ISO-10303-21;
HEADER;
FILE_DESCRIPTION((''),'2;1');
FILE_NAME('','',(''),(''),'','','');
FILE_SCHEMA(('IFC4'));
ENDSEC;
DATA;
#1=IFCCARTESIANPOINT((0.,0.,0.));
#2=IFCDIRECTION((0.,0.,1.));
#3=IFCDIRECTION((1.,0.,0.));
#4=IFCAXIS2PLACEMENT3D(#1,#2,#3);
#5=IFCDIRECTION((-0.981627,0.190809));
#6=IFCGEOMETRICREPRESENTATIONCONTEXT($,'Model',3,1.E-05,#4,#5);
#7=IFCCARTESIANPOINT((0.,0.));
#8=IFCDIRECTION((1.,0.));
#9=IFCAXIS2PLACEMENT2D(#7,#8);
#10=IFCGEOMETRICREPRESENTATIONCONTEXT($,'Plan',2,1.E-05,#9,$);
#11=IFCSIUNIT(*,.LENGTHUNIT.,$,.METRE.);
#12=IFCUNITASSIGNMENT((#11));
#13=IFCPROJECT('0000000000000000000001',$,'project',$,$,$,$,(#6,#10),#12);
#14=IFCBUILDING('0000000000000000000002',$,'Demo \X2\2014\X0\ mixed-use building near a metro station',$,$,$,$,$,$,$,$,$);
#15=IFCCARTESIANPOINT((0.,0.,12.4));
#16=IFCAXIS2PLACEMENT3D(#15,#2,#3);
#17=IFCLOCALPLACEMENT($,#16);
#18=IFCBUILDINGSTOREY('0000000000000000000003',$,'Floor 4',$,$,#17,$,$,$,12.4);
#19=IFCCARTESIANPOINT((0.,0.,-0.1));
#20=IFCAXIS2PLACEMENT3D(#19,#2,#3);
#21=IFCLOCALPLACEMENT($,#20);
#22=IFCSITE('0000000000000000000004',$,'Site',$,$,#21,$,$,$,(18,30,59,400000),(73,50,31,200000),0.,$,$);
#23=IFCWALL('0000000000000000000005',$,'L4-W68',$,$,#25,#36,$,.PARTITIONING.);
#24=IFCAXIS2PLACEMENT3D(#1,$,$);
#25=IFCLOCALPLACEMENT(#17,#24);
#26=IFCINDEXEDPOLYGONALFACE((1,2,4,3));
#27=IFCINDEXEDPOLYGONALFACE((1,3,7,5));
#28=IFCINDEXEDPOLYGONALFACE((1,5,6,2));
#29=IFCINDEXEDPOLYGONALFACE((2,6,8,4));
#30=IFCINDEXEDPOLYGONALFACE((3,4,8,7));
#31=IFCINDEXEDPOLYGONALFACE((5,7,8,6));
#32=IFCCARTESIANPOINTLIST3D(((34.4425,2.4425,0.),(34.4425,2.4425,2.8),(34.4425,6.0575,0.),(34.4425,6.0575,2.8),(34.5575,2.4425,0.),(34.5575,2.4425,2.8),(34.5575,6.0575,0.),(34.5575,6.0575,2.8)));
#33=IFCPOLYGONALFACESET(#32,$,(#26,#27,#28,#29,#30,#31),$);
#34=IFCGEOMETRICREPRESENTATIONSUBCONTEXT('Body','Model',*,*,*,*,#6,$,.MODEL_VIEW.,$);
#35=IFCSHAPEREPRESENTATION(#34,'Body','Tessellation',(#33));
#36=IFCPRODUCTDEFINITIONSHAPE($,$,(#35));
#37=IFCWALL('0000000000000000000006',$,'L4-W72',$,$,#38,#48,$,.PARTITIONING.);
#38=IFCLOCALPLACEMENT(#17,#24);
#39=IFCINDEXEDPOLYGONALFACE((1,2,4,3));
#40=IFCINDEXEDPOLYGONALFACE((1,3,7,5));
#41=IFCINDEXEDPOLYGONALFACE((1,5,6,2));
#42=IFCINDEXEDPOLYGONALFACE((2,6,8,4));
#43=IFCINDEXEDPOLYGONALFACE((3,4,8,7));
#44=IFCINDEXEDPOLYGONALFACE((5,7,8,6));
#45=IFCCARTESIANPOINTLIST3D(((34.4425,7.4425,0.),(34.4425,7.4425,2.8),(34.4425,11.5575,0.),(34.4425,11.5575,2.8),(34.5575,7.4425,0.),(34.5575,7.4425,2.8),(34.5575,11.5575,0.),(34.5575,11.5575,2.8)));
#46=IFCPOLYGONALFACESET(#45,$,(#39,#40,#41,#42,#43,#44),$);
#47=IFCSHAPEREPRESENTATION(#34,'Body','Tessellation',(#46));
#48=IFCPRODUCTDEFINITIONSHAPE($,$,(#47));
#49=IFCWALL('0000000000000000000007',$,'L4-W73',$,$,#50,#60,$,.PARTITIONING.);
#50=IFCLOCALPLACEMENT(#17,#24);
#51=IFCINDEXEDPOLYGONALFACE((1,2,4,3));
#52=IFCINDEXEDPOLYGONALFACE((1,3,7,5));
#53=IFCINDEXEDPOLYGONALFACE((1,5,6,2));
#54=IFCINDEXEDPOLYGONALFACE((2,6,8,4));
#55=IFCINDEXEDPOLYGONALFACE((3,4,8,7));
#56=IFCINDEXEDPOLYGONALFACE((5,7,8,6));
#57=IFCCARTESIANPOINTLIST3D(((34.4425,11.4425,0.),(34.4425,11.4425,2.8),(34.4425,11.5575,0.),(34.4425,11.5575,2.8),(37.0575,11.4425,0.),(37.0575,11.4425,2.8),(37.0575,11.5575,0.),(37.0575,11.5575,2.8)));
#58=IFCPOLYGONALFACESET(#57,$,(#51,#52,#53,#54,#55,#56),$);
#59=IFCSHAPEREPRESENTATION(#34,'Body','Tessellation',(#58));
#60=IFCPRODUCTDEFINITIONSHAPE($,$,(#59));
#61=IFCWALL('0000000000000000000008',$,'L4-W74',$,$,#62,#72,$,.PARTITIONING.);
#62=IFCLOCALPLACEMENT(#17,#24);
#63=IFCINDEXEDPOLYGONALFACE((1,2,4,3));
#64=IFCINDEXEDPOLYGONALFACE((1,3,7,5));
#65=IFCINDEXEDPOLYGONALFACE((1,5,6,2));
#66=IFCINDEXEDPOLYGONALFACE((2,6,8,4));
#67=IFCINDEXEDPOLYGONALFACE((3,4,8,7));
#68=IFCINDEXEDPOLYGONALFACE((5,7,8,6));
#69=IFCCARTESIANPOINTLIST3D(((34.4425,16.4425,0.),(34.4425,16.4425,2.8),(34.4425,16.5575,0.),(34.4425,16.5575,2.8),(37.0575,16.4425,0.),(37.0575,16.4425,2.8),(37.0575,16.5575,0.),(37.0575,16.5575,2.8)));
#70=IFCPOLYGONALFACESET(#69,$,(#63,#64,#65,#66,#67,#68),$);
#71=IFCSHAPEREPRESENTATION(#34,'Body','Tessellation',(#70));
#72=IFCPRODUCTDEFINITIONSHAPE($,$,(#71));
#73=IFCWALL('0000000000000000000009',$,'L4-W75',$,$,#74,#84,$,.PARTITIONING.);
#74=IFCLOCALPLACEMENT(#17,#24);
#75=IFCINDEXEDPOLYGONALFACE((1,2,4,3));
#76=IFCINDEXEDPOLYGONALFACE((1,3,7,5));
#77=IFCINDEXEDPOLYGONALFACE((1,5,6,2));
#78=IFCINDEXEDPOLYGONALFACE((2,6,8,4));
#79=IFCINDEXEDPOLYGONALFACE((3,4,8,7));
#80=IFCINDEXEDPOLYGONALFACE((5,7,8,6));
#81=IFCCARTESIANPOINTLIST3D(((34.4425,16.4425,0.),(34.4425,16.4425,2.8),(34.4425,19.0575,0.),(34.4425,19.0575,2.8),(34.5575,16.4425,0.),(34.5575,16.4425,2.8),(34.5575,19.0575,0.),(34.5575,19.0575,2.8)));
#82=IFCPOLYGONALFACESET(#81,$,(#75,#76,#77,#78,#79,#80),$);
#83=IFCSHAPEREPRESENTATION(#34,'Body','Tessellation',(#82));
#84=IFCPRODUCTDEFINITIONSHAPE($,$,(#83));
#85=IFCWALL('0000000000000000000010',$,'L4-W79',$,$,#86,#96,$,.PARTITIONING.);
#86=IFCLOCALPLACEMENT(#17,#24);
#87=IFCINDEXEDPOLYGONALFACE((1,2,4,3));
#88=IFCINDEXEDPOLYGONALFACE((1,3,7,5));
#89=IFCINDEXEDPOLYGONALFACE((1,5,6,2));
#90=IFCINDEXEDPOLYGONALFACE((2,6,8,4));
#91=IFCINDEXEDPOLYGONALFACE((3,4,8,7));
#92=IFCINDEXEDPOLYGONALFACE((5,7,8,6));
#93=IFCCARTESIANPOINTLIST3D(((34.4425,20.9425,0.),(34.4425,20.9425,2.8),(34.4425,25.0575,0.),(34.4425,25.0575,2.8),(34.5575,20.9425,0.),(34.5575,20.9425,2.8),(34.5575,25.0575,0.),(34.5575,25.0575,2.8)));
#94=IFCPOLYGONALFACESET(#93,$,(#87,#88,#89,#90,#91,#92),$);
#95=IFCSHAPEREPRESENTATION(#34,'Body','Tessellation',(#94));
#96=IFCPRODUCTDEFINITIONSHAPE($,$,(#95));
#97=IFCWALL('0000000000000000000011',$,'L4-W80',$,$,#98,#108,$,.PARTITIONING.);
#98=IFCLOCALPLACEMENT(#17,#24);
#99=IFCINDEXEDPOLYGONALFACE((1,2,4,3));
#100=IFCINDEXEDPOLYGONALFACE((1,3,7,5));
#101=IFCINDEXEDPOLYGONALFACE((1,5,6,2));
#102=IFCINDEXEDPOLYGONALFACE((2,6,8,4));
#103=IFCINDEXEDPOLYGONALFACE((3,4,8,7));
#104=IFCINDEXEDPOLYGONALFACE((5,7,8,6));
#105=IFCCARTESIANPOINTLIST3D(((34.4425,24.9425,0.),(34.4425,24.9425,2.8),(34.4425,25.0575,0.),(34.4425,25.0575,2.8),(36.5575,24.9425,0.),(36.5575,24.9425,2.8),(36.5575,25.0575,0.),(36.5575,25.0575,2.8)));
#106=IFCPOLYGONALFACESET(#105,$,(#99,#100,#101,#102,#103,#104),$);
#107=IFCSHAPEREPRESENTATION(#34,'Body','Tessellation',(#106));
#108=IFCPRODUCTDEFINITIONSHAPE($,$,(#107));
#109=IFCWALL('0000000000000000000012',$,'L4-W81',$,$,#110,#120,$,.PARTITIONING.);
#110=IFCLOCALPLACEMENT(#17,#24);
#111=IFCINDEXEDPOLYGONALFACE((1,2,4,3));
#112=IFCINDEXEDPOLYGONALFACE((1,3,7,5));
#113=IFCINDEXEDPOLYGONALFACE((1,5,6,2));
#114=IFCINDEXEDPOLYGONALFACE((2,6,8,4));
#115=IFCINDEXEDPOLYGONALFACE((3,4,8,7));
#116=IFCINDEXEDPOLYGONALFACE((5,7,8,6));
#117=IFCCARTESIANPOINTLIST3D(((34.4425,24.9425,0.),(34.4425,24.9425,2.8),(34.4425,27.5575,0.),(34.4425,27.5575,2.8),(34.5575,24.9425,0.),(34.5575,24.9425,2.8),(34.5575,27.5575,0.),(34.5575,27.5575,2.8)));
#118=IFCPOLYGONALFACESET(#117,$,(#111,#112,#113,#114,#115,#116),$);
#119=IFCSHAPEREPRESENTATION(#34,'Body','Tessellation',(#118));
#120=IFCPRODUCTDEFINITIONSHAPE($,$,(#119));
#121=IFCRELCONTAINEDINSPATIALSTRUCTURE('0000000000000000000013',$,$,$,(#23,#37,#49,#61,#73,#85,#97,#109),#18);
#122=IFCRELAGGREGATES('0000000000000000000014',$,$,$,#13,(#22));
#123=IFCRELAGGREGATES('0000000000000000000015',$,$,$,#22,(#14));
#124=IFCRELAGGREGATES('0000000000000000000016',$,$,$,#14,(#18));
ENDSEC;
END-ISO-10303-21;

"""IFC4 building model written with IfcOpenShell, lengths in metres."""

from ifc_helpers import new_model, si_unit, direction, frame, origin_with_axes, origin_2d_with_axis, place, context, subcontext, project, spatial, line, indexed_curve, outline, extrude, element, save


model = new_model("IFC4")

# Units and contexts
model_context = context("Model", 3, precision=1e-05, world=origin_with_axes(), true_north=direction((-0.981627, 0.190809)))
plan_context = context("Plan", 2, precision=1e-05, world=origin_2d_with_axis())
body_context = subcontext(model_context, "Body", "Model", "MODEL_VIEW")
ifc_project = project(units=[si_unit("LENGTHUNIT", "METRE")], contexts=[model_context, plan_context])

# Site, building, storey
site_placement = place(None, frame((0.0, 0.0, -0.1), z_axis=(0.0, 0.0, 1.0), x_axis=(1.0, 0.0, 0.0)))
site = spatial("IfcSite", under=ifc_project, at=site_placement, Name="Site", RefLatitude=(18, 30, 59, 400000), RefLongitude=(73, 50, 31, 200000), RefElevation=0.0)
building = spatial("IfcBuilding", under=site, Name="Demo — mixed-use building near a metro station")
storey_placement = place(None, frame((0.0, 0.0, 12.4), z_axis=(0.0, 0.0, 1.0), x_axis=(1.0, 0.0, 0.0)))
storey = spatial("IfcBuildingStorey", under=building, at=storey_placement, Name="Floor 4", Elevation=12.4)

# Wall
wall_1_placement = place(storey_placement, frame((0.0, 0.0, -12.4), z_axis=(0.0, 0.0, 1.0), x_axis=(1.0, 0.0, 0.0)))
element("IfcWall", 1, at=wall_1_placement, inside=storey, Name="L4-W68", PredefinedType="PARTITIONING", context=body_context, shape_type="SweptSolid", body=[
    extrude(outline(indexed_curve([(34.4425, 2.4425), (34.4425, 6.0575), (34.5575, 6.0575), (34.5575, 2.4425)], segments=[line(1, 2, 3, 4, 1)])), frame((0.0, 0.0, 12.4), z_axis=(0.0, 0.0, 1.0), x_axis=(1.0, 0.0, 0.0)), (0.0, 0.0, 1.0), 2.8),
])

# Walls
wall_2_placement = place(storey_placement, frame((0.0, 0.0, -12.4), z_axis=(0.0, 0.0, 1.0), x_axis=(1.0, 0.0, 0.0)))
element("IfcWall", 2, at=wall_2_placement, inside=storey, Name="L4-W72", PredefinedType="PARTITIONING", context=body_context, shape_type="SweptSolid", body=[
    extrude(outline(indexed_curve([(34.4425, 7.4425), (34.4425, 11.5575), (34.5575, 11.5575), (34.5575, 7.4425)], segments=[line(1, 2, 3, 4, 1)])), frame((0.0, 0.0, 12.4), z_axis=(0.0, 0.0, 1.0), x_axis=(1.0, 0.0, 0.0)), (0.0, 0.0, 1.0), 2.8),
])
wall_3_placement = place(storey_placement, frame((0.0, 0.0, -12.4), z_axis=(0.0, 0.0, 1.0), x_axis=(1.0, 0.0, 0.0)))
element("IfcWall", 3, at=wall_3_placement, inside=storey, Name="L4-W73", PredefinedType="PARTITIONING", context=body_context, shape_type="SweptSolid", body=[
    extrude(outline(indexed_curve([(34.4425, 11.5575), (37.0575, 11.5575), (37.0575, 11.4425), (34.4425, 11.4425)], segments=[line(1, 2, 3, 4, 1)])), frame((0.0, 0.0, 12.4), z_axis=(0.0, 0.0, 1.0), x_axis=(1.0, 0.0, 0.0)), (0.0, 0.0, 1.0), 2.8),
])
wall_4_placement = place(storey_placement, frame((0.0, 0.0, -12.4), z_axis=(0.0, 0.0, 1.0), x_axis=(1.0, 0.0, 0.0)))
element("IfcWall", 4, at=wall_4_placement, inside=storey, Name="L4-W74", PredefinedType="PARTITIONING", context=body_context, shape_type="SweptSolid", body=[
    extrude(outline(indexed_curve([(37.0575, 16.4425), (34.4425, 16.4425), (34.4425, 16.5575), (37.0575, 16.5575)], segments=[line(1, 2, 3, 4, 1)])), frame((0.0, 0.0, 12.4), z_axis=(0.0, 0.0, 1.0), x_axis=(1.0, 0.0, 0.0)), (0.0, 0.0, 1.0), 2.8),
])
wall_5_placement = place(storey_placement, frame((0.0, 0.0, -12.4), z_axis=(0.0, 0.0, 1.0), x_axis=(1.0, 0.0, 0.0)))
element("IfcWall", 5, at=wall_5_placement, inside=storey, Name="L4-W75", PredefinedType="PARTITIONING", context=body_context, shape_type="SweptSolid", body=[
    extrude(outline(indexed_curve([(34.4425, 16.4425), (34.4425, 19.0575), (34.5575, 19.0575), (34.5575, 16.4425)], segments=[line(1, 2, 3, 4, 1)])), frame((0.0, 0.0, 12.4), z_axis=(0.0, 0.0, 1.0), x_axis=(1.0, 0.0, 0.0)), (0.0, 0.0, 1.0), 2.8),
])

# Walls
wall_6_placement = place(storey_placement, frame((0.0, 0.0, -12.4), z_axis=(0.0, 0.0, 1.0), x_axis=(1.0, 0.0, 0.0)))
element("IfcWall", 6, at=wall_6_placement, inside=storey, Name="L4-W79", PredefinedType="PARTITIONING", context=body_context, shape_type="SweptSolid", body=[
    extrude(outline(indexed_curve([(34.4425, 20.9425), (34.4425, 25.0575), (34.5575, 25.0575), (34.5575, 20.9425)], segments=[line(1, 2, 3, 4, 1)])), frame((0.0, 0.0, 12.4), z_axis=(0.0, 0.0, 1.0), x_axis=(1.0, 0.0, 0.0)), (0.0, 0.0, 1.0), 2.8),
])
wall_7_placement = place(storey_placement, frame((0.0, 0.0, -12.4), z_axis=(0.0, 0.0, 1.0), x_axis=(1.0, 0.0, 0.0)))
element("IfcWall", 7, at=wall_7_placement, inside=storey, Name="L4-W80", PredefinedType="PARTITIONING", context=body_context, shape_type="SweptSolid", body=[
    extrude(outline(indexed_curve([(36.5575, 24.9425), (34.4425, 24.9425), (34.4425, 25.0575), (36.5575, 25.0575)], segments=[line(1, 2, 3, 4, 1)])), frame((0.0, 0.0, 12.4), z_axis=(0.0, 0.0, 1.0), x_axis=(1.0, 0.0, 0.0)), (0.0, 0.0, 1.0), 2.8),
])
wall_8_placement = place(storey_placement, frame((0.0, 0.0, -12.4), z_axis=(0.0, 0.0, 1.0), x_axis=(1.0, 0.0, 0.0)))
element("IfcWall", 8, at=wall_8_placement, inside=storey, Name="L4-W81", PredefinedType="PARTITIONING", context=body_context, shape_type="SweptSolid", body=[
    extrude(outline(indexed_curve([(34.4425, 24.9425), (34.4425, 27.5575), (34.5575, 27.5575), (34.5575, 24.9425)], segments=[line(1, 2, 3, 4, 1)])), frame((0.0, 0.0, 12.4), z_axis=(0.0, 0.0, 1.0), x_axis=(1.0, 0.0, 0.0)), (0.0, 0.0, 1.0), 2.8),
])

save(model, "model.ifc")
